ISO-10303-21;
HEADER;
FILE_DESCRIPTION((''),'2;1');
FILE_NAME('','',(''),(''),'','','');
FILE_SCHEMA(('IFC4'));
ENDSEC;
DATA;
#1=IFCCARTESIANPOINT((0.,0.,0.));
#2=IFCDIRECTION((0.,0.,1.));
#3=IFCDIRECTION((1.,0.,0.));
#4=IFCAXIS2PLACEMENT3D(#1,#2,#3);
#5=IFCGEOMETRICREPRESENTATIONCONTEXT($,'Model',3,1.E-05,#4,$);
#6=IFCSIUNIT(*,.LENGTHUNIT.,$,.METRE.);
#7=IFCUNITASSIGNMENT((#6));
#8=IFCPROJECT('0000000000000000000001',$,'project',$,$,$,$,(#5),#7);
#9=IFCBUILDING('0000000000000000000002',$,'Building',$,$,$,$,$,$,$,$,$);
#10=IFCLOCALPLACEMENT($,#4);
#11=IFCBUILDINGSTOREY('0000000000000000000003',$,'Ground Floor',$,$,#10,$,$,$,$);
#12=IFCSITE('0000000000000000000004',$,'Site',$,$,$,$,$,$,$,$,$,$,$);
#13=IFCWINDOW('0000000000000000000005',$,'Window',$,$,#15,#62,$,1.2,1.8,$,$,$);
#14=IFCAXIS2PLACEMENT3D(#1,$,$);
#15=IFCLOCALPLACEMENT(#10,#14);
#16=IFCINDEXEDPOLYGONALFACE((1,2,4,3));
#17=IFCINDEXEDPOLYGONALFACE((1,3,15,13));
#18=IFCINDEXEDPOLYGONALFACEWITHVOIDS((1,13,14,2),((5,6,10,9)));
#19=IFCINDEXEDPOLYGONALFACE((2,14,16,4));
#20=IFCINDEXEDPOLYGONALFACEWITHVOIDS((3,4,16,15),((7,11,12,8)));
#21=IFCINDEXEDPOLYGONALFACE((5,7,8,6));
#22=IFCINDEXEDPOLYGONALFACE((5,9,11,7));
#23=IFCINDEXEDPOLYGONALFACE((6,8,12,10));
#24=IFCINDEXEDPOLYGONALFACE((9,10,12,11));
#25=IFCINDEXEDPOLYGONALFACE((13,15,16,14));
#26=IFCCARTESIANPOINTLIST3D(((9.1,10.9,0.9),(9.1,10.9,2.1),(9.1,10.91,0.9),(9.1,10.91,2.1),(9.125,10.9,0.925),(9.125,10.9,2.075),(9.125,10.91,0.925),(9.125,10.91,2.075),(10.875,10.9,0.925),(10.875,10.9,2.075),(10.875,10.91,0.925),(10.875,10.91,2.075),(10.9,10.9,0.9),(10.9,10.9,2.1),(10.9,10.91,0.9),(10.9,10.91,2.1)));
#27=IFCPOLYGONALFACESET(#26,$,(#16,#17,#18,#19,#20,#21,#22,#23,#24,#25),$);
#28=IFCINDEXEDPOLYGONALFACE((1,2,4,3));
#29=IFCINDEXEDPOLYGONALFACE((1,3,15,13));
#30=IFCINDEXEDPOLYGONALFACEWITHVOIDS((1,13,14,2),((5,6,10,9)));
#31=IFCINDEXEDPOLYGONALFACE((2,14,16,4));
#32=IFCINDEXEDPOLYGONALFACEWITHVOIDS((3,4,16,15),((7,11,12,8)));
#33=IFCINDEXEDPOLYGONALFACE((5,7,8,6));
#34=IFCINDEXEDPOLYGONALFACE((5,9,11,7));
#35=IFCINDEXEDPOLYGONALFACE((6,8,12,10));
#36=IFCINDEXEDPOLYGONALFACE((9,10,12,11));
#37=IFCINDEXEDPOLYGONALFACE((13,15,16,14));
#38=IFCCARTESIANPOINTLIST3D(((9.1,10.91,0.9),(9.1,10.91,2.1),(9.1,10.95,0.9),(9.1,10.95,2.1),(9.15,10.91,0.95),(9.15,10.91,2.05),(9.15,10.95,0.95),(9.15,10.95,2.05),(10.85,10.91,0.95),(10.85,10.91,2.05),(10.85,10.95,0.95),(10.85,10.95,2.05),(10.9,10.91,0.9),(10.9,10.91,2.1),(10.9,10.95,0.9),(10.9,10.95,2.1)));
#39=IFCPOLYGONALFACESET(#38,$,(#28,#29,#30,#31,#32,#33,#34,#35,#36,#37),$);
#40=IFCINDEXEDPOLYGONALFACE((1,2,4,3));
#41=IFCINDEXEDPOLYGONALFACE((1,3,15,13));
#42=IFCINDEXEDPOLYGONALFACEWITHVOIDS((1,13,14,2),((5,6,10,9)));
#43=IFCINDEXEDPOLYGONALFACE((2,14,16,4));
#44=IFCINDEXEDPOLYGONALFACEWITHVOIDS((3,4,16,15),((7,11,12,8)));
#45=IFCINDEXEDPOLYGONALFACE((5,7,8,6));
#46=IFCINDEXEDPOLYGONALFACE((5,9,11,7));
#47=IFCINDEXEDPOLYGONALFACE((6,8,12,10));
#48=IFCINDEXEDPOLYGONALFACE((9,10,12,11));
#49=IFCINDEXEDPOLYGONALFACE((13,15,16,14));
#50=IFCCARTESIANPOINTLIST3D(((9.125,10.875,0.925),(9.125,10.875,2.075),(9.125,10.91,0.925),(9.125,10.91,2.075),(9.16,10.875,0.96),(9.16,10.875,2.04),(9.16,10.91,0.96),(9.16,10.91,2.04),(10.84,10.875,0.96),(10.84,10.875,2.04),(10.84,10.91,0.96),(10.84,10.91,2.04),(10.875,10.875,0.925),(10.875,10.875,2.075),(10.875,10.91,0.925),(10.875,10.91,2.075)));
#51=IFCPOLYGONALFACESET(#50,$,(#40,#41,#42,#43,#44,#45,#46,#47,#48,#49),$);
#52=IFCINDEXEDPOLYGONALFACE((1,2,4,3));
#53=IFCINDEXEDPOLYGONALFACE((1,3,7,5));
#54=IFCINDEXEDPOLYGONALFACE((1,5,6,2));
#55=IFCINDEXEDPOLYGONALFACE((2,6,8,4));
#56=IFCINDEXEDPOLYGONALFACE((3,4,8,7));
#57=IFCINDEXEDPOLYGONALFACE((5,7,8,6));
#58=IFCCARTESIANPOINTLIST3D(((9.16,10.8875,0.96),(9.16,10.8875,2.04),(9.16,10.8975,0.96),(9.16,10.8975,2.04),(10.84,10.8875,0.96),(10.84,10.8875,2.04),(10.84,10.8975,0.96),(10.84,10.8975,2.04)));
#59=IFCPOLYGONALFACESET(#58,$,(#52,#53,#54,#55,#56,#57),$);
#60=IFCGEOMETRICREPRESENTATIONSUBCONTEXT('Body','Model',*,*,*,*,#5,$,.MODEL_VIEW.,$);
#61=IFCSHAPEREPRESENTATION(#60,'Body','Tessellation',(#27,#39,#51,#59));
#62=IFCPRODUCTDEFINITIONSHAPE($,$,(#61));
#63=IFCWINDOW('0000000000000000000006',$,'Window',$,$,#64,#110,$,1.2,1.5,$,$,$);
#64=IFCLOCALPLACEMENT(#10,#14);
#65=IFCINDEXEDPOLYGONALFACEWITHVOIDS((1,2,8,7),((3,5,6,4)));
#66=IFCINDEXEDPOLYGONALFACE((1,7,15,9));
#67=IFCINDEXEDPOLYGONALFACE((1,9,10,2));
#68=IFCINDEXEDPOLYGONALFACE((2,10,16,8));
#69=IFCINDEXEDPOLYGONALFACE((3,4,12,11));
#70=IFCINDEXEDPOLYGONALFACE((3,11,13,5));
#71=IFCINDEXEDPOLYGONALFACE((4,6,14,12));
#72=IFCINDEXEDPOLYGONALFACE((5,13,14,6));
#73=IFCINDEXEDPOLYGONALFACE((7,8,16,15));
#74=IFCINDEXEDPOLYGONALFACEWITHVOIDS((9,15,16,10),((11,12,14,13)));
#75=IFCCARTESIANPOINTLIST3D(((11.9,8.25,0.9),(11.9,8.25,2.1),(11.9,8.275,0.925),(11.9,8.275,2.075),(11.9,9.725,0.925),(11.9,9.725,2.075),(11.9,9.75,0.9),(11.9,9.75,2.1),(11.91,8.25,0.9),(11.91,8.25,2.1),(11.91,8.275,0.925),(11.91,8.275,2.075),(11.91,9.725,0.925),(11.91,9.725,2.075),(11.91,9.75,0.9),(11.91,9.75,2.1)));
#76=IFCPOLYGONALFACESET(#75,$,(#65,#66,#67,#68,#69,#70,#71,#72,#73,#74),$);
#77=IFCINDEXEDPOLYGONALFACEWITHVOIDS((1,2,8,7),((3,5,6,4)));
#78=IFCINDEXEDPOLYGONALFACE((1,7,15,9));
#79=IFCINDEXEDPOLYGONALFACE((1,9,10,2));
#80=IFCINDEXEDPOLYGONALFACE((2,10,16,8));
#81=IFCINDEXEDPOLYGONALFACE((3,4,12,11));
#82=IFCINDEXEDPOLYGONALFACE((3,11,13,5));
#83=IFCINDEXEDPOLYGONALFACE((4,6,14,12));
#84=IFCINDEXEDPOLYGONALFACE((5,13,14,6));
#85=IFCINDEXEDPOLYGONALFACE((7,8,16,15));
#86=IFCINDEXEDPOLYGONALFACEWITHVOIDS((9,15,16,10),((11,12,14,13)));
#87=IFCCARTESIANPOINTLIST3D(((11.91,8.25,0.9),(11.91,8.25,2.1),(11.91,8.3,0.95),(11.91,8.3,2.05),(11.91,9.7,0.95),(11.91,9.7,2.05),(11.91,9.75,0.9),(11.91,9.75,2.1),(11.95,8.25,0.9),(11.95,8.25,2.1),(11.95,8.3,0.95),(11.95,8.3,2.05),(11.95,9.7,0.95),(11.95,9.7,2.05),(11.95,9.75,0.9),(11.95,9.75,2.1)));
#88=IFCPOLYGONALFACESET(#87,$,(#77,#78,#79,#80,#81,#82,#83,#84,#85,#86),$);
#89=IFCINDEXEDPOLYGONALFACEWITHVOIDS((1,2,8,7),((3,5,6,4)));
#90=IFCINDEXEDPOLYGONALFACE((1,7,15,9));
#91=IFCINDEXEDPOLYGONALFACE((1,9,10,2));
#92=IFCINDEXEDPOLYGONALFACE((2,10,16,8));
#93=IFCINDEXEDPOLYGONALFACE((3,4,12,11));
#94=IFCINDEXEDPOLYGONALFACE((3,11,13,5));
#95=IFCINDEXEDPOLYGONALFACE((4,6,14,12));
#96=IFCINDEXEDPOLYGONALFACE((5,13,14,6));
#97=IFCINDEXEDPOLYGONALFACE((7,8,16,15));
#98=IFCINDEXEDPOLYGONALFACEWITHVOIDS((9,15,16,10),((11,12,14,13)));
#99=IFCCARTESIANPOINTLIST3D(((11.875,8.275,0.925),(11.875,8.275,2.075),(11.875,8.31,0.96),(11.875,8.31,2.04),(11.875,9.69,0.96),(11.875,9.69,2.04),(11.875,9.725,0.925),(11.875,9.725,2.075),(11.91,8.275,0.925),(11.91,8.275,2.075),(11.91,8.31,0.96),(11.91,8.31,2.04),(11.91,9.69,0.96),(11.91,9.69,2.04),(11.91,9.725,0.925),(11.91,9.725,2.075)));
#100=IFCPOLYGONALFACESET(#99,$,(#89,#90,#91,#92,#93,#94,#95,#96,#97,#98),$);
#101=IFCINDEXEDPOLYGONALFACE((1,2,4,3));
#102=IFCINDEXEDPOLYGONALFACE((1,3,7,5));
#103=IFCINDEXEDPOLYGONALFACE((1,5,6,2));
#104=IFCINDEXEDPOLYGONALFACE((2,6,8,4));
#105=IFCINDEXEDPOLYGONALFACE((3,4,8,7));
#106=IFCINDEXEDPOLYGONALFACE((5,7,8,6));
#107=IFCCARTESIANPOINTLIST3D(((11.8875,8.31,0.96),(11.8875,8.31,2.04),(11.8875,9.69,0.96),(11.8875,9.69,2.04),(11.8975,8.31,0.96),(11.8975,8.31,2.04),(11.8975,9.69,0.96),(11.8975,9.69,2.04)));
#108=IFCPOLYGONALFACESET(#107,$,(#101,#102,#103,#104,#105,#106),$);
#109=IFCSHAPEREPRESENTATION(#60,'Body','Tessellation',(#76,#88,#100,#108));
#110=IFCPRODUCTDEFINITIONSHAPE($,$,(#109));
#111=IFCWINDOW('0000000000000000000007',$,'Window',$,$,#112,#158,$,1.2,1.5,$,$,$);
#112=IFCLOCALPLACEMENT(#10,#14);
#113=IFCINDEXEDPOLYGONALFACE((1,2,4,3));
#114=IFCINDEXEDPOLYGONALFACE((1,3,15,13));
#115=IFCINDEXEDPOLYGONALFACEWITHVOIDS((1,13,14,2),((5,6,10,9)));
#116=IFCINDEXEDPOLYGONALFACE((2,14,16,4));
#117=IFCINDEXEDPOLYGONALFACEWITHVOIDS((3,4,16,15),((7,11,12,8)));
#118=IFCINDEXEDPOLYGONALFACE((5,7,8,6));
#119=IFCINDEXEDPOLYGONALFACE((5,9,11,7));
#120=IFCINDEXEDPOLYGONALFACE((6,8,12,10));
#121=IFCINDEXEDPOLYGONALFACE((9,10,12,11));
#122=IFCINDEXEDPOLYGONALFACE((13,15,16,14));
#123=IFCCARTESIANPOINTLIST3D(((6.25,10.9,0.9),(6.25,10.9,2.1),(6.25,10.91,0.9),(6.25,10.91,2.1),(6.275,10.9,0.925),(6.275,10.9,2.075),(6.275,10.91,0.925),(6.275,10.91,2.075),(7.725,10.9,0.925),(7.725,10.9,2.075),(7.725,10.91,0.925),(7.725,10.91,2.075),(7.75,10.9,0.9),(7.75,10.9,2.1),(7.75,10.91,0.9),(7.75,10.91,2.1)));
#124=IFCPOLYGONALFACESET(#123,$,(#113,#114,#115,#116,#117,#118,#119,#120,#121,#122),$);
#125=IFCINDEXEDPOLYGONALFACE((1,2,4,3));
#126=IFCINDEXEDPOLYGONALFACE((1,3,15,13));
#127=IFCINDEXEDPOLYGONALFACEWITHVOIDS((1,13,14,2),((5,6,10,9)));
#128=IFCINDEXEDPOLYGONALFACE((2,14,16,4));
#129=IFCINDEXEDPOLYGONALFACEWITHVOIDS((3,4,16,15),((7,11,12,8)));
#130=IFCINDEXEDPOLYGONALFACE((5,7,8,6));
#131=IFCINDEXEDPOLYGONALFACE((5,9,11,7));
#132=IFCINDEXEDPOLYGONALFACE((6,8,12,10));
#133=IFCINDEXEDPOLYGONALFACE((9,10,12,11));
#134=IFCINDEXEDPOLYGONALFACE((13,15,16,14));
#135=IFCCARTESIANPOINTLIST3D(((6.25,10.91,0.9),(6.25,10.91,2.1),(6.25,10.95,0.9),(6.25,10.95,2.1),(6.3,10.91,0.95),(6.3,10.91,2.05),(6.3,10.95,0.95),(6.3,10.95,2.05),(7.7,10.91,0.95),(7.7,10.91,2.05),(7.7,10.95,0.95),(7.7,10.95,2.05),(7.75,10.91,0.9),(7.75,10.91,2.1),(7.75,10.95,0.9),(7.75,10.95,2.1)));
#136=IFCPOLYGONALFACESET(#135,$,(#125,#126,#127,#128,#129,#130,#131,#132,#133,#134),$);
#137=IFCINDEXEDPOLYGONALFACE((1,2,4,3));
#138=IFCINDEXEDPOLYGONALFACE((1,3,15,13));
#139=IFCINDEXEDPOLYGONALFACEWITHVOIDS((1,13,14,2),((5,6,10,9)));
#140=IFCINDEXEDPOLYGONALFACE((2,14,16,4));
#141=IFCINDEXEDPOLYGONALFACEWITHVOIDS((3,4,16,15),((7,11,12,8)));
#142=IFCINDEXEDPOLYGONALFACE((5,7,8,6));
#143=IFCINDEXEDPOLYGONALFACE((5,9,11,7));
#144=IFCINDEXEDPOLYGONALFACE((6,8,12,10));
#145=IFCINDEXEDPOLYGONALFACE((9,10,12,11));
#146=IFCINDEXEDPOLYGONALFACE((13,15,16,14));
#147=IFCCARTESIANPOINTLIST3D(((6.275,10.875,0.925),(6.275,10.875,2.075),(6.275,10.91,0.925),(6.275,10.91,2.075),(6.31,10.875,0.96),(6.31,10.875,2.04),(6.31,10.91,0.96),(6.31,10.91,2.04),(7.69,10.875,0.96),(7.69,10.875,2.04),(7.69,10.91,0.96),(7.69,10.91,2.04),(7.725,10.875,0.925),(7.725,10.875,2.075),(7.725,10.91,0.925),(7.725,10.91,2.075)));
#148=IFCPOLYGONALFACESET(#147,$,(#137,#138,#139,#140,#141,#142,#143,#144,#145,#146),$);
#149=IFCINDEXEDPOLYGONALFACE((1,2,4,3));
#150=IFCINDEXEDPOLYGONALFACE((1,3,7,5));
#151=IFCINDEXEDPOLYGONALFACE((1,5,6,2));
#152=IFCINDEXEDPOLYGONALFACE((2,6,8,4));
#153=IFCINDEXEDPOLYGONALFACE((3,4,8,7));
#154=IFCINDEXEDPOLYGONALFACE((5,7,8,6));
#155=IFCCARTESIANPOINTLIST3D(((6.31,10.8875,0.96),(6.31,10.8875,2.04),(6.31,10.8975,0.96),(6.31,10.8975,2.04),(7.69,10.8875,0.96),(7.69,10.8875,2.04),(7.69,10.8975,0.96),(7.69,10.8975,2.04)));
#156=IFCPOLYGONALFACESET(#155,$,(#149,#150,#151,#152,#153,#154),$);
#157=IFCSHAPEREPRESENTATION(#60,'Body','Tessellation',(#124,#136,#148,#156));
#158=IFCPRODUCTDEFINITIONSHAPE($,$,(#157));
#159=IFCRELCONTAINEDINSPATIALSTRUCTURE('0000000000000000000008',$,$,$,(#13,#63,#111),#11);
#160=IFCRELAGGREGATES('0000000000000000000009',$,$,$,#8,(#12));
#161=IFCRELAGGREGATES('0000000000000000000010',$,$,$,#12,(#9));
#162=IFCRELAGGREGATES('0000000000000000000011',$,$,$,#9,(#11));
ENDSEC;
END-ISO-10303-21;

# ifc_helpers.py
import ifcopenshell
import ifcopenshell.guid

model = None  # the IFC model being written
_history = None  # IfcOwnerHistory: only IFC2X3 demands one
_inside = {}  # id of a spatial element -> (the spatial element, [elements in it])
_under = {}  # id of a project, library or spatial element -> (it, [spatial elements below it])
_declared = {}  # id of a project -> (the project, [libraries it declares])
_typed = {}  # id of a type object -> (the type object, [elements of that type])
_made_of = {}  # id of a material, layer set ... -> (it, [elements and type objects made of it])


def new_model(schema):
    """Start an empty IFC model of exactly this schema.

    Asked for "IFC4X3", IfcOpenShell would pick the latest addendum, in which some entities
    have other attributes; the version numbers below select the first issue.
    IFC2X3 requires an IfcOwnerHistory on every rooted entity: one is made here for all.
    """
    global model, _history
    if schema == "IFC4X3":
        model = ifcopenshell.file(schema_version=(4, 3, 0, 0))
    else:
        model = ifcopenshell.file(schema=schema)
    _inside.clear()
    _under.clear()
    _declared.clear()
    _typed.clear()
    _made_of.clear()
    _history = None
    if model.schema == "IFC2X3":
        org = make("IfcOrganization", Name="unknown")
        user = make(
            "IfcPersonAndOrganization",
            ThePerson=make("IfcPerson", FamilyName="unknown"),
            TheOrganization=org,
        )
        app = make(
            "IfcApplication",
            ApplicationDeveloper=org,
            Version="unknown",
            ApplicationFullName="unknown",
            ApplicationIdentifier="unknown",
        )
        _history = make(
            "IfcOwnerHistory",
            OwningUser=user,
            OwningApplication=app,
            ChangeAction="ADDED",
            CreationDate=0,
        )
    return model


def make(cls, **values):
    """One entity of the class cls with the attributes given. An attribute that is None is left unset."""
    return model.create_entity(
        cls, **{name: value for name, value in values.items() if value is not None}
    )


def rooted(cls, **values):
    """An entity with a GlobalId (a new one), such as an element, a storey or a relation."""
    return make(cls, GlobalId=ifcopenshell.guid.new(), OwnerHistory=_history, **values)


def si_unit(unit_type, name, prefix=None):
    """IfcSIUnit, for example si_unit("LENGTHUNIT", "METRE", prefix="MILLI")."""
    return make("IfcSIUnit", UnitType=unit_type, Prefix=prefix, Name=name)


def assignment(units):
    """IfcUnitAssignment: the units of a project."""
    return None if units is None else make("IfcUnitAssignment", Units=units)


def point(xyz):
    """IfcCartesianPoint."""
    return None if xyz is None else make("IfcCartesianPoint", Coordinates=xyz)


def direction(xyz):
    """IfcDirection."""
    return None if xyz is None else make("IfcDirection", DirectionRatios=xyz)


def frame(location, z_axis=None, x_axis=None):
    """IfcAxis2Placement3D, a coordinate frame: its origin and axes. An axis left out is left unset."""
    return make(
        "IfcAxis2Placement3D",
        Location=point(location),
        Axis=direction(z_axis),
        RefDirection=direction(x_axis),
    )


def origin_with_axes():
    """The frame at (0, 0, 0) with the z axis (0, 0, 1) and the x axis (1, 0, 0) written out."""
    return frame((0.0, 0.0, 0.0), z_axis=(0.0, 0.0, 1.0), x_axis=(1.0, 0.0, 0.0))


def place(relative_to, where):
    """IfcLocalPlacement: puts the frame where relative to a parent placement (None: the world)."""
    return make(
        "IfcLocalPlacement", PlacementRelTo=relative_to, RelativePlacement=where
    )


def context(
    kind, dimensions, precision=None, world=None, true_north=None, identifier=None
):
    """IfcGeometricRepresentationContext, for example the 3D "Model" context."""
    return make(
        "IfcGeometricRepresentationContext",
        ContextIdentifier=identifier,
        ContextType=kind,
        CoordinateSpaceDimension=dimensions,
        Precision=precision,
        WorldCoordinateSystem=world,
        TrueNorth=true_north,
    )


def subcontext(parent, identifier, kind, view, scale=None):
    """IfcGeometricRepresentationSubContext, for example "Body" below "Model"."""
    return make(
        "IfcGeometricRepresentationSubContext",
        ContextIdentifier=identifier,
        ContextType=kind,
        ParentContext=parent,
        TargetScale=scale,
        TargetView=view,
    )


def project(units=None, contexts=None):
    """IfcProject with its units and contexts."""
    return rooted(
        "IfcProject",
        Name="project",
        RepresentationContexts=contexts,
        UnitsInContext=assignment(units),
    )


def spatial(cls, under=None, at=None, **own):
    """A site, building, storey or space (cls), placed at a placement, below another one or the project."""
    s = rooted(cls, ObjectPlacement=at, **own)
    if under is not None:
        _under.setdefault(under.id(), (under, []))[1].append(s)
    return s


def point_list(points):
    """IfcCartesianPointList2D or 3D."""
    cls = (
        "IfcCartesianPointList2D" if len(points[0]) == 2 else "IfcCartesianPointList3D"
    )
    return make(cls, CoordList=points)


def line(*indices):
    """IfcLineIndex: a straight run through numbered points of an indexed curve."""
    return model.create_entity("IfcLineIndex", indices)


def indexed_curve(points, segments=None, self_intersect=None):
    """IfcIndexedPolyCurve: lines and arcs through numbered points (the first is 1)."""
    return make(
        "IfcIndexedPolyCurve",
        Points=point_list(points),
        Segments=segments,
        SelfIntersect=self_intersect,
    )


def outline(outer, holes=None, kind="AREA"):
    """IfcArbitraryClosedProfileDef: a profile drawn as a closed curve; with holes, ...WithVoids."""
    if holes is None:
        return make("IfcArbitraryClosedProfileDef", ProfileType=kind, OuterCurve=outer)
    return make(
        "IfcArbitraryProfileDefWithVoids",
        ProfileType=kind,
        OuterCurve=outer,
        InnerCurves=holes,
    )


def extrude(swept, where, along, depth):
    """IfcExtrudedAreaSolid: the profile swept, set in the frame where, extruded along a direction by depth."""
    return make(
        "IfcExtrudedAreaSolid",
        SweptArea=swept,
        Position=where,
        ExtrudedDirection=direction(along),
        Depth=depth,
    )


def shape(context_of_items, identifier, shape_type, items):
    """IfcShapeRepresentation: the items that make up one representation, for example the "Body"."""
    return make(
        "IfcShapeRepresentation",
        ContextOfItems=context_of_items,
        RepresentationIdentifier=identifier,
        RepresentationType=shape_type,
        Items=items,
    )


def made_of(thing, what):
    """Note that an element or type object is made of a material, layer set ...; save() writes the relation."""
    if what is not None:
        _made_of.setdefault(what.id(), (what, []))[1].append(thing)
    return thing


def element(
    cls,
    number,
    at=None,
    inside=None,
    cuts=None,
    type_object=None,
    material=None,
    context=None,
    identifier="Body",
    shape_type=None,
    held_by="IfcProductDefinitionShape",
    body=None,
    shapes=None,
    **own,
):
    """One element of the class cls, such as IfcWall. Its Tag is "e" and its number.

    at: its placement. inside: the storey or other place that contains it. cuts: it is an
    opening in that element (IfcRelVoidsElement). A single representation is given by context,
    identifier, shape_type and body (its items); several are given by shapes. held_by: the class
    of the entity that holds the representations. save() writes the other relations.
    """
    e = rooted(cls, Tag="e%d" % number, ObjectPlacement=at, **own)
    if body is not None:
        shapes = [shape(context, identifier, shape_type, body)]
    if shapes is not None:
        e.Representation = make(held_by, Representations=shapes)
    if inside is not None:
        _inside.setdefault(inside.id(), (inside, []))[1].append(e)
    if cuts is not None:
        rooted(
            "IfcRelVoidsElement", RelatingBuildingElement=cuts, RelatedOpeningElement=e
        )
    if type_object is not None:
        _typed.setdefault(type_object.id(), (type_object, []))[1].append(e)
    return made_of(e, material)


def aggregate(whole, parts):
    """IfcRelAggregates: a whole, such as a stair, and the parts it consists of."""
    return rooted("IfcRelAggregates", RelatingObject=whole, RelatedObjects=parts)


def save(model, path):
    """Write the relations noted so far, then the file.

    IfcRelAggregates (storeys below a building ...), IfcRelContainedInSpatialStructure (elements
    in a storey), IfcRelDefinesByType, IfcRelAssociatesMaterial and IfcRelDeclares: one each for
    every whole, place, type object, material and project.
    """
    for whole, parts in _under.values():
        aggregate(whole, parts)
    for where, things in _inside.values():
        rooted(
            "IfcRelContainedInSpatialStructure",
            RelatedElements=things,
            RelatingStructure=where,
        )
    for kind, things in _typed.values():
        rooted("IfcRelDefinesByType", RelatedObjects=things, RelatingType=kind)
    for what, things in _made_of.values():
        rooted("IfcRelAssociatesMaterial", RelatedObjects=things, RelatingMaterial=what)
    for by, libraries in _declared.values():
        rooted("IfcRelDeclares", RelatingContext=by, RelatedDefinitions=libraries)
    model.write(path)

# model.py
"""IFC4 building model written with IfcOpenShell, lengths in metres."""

from ifc_helpers import new_model, si_unit, frame, origin_with_axes, place, context, subcontext, project, spatial, line, indexed_curve, outline, extrude, element, save


model = new_model("IFC4")

# Units and contexts
model_context = context("Model", 3, precision=1e-05, world=origin_with_axes())
body_context = subcontext(model_context, "Body", "Model", "MODEL_VIEW")
ifc_project = project(units=[si_unit("LENGTHUNIT", "METRE")], contexts=[model_context])

# Site, building, storey
site = spatial("IfcSite", under=ifc_project, Name="Site")
building = spatial("IfcBuilding", under=site, Name="Building")
storey_placement = place(None, origin_with_axes())
storey = spatial("IfcBuildingStorey", under=building, at=storey_placement, Name="Ground Floor")

# Windows
window_placement = place(storey_placement, frame((10.9, 11.0, 0.9), z_axis=(0.0, 0.0, 1.0), x_axis=(-1.0, 0.0, 0.0)))
element("IfcWindow", 1, at=window_placement, inside=storey, Name="Window", OverallHeight=1.2, OverallWidth=1.8, context=body_context, shape_type="SweptSolid", body=[
    extrude(outline(indexed_curve([(0.0, 0.0), (1.8, 0.0), (1.8, 1.2), (0.0, 1.2)], segments=[line(1, 2, 3, 4, 1)]), holes=[indexed_curve([(0.025, 0.025), (1.775, 0.025), (1.775, 1.175), (0.025, 1.175)], segments=[line(1, 2, 3, 4, 1)])]), frame((0.0, 0.09, 0.0), z_axis=(0.0, -1.0, 0.0), x_axis=(1.0, 0.0, 0.0)), (0.0, 0.0, -1.0), 0.01),
    extrude(outline(indexed_curve([(0.0, 0.0), (1.8, 0.0), (1.8, 1.2), (0.0, 1.2)], segments=[line(1, 2, 3, 4, 1)]), holes=[indexed_curve([(0.05, 0.05), (1.75, 0.05), (1.75, 1.15), (0.05, 1.15)], segments=[line(1, 2, 3, 4, 1)])]), frame((0.0, 0.05, 0.0), z_axis=(0.0, -1.0, 0.0), x_axis=(1.0, 0.0, 0.0)), (0.0, 0.0, -1.0), 0.04),
    extrude(outline(indexed_curve([(0.0, 0.0), (1.75, 0.0), (1.75, 1.15), (0.0, 1.15)], segments=[line(1, 2, 3, 4, 1)]), holes=[indexed_curve([(0.035, 0.035), (1.715, 0.035), (1.715, 1.115), (0.035, 1.115)], segments=[line(1, 2, 3, 4, 1)])]), frame((0.025, 0.09, 0.025), z_axis=(0.0, -1.0, 0.0), x_axis=(1.0, 0.0, 0.0)), (0.0, 0.0, -1.0), 0.035),
    extrude(outline(indexed_curve([(0.035, 0.035), (1.715, 0.035), (1.715, 1.115), (0.035, 1.115)], segments=[line(1, 2, 3, 4, 1)])), frame((0.025, 0.1025, 0.025), z_axis=(0.0, -1.0, 0.0), x_axis=(1.0, 0.0, 0.0)), (0.0, 0.0, -1.0), 0.01),
])
for number, where, z_axis, x_axis, name in (
    (2, (12.0, 8.25, 0.9), (0.0, 0.0, 1.0), (0.0, 1.0, 0.0), "Window"),
    (3, (7.75, 11.0, 0.9), (0.0, 0.0, 1.0), (-1.0, 0.0, 0.0), "Window"),
):
    element("IfcWindow", number, at=place(storey_placement, frame(where, z_axis=z_axis, x_axis=x_axis)), inside=storey, Name=name, OverallHeight=1.2, OverallWidth=1.5, context=body_context, shape_type="SweptSolid", body=[
        extrude(outline(indexed_curve([(0.0, 0.0), (1.5, 0.0), (1.5, 1.2), (0.0, 1.2)], segments=[line(1, 2, 3, 4, 1)]), holes=[indexed_curve([(0.025, 0.025), (1.475, 0.025), (1.475, 1.175), (0.025, 1.175)], segments=[line(1, 2, 3, 4, 1)])]), frame((0.0, 0.09, 0.0), z_axis=(0.0, -1.0, 0.0), x_axis=(1.0, 0.0, 0.0)), (0.0, 0.0, -1.0), 0.01),
        extrude(outline(indexed_curve([(0.0, 0.0), (1.5, 0.0), (1.5, 1.2), (0.0, 1.2)], segments=[line(1, 2, 3, 4, 1)]), holes=[indexed_curve([(0.05, 0.05), (1.45, 0.05), (1.45, 1.15), (0.05, 1.15)], segments=[line(1, 2, 3, 4, 1)])]), frame((0.0, 0.05, 0.0), z_axis=(0.0, -1.0, 0.0), x_axis=(1.0, 0.0, 0.0)), (0.0, 0.0, -1.0), 0.04),
        extrude(outline(indexed_curve([(0.0, 0.0), (1.45, 0.0), (1.45, 1.15), (0.0, 1.15)], segments=[line(1, 2, 3, 4, 1)]), holes=[indexed_curve([(0.035, 0.035), (1.415, 0.035), (1.415, 1.115), (0.035, 1.115)], segments=[line(1, 2, 3, 4, 1)])]), frame((0.025, 0.09, 0.025), z_axis=(0.0, -1.0, 0.0), x_axis=(1.0, 0.0, 0.0)), (0.0, 0.0, -1.0), 0.035),
        extrude(outline(indexed_curve([(0.035, 0.035), (1.415, 0.035), (1.415, 1.115), (0.035, 1.115)], segments=[line(1, 2, 3, 4, 1)])), frame((0.025, 0.1025, 0.025), z_axis=(0.0, -1.0, 0.0), x_axis=(1.0, 0.0, 0.0)), (0.0, 0.0, -1.0), 0.01),
    ])

save(model, "model.ifc")
